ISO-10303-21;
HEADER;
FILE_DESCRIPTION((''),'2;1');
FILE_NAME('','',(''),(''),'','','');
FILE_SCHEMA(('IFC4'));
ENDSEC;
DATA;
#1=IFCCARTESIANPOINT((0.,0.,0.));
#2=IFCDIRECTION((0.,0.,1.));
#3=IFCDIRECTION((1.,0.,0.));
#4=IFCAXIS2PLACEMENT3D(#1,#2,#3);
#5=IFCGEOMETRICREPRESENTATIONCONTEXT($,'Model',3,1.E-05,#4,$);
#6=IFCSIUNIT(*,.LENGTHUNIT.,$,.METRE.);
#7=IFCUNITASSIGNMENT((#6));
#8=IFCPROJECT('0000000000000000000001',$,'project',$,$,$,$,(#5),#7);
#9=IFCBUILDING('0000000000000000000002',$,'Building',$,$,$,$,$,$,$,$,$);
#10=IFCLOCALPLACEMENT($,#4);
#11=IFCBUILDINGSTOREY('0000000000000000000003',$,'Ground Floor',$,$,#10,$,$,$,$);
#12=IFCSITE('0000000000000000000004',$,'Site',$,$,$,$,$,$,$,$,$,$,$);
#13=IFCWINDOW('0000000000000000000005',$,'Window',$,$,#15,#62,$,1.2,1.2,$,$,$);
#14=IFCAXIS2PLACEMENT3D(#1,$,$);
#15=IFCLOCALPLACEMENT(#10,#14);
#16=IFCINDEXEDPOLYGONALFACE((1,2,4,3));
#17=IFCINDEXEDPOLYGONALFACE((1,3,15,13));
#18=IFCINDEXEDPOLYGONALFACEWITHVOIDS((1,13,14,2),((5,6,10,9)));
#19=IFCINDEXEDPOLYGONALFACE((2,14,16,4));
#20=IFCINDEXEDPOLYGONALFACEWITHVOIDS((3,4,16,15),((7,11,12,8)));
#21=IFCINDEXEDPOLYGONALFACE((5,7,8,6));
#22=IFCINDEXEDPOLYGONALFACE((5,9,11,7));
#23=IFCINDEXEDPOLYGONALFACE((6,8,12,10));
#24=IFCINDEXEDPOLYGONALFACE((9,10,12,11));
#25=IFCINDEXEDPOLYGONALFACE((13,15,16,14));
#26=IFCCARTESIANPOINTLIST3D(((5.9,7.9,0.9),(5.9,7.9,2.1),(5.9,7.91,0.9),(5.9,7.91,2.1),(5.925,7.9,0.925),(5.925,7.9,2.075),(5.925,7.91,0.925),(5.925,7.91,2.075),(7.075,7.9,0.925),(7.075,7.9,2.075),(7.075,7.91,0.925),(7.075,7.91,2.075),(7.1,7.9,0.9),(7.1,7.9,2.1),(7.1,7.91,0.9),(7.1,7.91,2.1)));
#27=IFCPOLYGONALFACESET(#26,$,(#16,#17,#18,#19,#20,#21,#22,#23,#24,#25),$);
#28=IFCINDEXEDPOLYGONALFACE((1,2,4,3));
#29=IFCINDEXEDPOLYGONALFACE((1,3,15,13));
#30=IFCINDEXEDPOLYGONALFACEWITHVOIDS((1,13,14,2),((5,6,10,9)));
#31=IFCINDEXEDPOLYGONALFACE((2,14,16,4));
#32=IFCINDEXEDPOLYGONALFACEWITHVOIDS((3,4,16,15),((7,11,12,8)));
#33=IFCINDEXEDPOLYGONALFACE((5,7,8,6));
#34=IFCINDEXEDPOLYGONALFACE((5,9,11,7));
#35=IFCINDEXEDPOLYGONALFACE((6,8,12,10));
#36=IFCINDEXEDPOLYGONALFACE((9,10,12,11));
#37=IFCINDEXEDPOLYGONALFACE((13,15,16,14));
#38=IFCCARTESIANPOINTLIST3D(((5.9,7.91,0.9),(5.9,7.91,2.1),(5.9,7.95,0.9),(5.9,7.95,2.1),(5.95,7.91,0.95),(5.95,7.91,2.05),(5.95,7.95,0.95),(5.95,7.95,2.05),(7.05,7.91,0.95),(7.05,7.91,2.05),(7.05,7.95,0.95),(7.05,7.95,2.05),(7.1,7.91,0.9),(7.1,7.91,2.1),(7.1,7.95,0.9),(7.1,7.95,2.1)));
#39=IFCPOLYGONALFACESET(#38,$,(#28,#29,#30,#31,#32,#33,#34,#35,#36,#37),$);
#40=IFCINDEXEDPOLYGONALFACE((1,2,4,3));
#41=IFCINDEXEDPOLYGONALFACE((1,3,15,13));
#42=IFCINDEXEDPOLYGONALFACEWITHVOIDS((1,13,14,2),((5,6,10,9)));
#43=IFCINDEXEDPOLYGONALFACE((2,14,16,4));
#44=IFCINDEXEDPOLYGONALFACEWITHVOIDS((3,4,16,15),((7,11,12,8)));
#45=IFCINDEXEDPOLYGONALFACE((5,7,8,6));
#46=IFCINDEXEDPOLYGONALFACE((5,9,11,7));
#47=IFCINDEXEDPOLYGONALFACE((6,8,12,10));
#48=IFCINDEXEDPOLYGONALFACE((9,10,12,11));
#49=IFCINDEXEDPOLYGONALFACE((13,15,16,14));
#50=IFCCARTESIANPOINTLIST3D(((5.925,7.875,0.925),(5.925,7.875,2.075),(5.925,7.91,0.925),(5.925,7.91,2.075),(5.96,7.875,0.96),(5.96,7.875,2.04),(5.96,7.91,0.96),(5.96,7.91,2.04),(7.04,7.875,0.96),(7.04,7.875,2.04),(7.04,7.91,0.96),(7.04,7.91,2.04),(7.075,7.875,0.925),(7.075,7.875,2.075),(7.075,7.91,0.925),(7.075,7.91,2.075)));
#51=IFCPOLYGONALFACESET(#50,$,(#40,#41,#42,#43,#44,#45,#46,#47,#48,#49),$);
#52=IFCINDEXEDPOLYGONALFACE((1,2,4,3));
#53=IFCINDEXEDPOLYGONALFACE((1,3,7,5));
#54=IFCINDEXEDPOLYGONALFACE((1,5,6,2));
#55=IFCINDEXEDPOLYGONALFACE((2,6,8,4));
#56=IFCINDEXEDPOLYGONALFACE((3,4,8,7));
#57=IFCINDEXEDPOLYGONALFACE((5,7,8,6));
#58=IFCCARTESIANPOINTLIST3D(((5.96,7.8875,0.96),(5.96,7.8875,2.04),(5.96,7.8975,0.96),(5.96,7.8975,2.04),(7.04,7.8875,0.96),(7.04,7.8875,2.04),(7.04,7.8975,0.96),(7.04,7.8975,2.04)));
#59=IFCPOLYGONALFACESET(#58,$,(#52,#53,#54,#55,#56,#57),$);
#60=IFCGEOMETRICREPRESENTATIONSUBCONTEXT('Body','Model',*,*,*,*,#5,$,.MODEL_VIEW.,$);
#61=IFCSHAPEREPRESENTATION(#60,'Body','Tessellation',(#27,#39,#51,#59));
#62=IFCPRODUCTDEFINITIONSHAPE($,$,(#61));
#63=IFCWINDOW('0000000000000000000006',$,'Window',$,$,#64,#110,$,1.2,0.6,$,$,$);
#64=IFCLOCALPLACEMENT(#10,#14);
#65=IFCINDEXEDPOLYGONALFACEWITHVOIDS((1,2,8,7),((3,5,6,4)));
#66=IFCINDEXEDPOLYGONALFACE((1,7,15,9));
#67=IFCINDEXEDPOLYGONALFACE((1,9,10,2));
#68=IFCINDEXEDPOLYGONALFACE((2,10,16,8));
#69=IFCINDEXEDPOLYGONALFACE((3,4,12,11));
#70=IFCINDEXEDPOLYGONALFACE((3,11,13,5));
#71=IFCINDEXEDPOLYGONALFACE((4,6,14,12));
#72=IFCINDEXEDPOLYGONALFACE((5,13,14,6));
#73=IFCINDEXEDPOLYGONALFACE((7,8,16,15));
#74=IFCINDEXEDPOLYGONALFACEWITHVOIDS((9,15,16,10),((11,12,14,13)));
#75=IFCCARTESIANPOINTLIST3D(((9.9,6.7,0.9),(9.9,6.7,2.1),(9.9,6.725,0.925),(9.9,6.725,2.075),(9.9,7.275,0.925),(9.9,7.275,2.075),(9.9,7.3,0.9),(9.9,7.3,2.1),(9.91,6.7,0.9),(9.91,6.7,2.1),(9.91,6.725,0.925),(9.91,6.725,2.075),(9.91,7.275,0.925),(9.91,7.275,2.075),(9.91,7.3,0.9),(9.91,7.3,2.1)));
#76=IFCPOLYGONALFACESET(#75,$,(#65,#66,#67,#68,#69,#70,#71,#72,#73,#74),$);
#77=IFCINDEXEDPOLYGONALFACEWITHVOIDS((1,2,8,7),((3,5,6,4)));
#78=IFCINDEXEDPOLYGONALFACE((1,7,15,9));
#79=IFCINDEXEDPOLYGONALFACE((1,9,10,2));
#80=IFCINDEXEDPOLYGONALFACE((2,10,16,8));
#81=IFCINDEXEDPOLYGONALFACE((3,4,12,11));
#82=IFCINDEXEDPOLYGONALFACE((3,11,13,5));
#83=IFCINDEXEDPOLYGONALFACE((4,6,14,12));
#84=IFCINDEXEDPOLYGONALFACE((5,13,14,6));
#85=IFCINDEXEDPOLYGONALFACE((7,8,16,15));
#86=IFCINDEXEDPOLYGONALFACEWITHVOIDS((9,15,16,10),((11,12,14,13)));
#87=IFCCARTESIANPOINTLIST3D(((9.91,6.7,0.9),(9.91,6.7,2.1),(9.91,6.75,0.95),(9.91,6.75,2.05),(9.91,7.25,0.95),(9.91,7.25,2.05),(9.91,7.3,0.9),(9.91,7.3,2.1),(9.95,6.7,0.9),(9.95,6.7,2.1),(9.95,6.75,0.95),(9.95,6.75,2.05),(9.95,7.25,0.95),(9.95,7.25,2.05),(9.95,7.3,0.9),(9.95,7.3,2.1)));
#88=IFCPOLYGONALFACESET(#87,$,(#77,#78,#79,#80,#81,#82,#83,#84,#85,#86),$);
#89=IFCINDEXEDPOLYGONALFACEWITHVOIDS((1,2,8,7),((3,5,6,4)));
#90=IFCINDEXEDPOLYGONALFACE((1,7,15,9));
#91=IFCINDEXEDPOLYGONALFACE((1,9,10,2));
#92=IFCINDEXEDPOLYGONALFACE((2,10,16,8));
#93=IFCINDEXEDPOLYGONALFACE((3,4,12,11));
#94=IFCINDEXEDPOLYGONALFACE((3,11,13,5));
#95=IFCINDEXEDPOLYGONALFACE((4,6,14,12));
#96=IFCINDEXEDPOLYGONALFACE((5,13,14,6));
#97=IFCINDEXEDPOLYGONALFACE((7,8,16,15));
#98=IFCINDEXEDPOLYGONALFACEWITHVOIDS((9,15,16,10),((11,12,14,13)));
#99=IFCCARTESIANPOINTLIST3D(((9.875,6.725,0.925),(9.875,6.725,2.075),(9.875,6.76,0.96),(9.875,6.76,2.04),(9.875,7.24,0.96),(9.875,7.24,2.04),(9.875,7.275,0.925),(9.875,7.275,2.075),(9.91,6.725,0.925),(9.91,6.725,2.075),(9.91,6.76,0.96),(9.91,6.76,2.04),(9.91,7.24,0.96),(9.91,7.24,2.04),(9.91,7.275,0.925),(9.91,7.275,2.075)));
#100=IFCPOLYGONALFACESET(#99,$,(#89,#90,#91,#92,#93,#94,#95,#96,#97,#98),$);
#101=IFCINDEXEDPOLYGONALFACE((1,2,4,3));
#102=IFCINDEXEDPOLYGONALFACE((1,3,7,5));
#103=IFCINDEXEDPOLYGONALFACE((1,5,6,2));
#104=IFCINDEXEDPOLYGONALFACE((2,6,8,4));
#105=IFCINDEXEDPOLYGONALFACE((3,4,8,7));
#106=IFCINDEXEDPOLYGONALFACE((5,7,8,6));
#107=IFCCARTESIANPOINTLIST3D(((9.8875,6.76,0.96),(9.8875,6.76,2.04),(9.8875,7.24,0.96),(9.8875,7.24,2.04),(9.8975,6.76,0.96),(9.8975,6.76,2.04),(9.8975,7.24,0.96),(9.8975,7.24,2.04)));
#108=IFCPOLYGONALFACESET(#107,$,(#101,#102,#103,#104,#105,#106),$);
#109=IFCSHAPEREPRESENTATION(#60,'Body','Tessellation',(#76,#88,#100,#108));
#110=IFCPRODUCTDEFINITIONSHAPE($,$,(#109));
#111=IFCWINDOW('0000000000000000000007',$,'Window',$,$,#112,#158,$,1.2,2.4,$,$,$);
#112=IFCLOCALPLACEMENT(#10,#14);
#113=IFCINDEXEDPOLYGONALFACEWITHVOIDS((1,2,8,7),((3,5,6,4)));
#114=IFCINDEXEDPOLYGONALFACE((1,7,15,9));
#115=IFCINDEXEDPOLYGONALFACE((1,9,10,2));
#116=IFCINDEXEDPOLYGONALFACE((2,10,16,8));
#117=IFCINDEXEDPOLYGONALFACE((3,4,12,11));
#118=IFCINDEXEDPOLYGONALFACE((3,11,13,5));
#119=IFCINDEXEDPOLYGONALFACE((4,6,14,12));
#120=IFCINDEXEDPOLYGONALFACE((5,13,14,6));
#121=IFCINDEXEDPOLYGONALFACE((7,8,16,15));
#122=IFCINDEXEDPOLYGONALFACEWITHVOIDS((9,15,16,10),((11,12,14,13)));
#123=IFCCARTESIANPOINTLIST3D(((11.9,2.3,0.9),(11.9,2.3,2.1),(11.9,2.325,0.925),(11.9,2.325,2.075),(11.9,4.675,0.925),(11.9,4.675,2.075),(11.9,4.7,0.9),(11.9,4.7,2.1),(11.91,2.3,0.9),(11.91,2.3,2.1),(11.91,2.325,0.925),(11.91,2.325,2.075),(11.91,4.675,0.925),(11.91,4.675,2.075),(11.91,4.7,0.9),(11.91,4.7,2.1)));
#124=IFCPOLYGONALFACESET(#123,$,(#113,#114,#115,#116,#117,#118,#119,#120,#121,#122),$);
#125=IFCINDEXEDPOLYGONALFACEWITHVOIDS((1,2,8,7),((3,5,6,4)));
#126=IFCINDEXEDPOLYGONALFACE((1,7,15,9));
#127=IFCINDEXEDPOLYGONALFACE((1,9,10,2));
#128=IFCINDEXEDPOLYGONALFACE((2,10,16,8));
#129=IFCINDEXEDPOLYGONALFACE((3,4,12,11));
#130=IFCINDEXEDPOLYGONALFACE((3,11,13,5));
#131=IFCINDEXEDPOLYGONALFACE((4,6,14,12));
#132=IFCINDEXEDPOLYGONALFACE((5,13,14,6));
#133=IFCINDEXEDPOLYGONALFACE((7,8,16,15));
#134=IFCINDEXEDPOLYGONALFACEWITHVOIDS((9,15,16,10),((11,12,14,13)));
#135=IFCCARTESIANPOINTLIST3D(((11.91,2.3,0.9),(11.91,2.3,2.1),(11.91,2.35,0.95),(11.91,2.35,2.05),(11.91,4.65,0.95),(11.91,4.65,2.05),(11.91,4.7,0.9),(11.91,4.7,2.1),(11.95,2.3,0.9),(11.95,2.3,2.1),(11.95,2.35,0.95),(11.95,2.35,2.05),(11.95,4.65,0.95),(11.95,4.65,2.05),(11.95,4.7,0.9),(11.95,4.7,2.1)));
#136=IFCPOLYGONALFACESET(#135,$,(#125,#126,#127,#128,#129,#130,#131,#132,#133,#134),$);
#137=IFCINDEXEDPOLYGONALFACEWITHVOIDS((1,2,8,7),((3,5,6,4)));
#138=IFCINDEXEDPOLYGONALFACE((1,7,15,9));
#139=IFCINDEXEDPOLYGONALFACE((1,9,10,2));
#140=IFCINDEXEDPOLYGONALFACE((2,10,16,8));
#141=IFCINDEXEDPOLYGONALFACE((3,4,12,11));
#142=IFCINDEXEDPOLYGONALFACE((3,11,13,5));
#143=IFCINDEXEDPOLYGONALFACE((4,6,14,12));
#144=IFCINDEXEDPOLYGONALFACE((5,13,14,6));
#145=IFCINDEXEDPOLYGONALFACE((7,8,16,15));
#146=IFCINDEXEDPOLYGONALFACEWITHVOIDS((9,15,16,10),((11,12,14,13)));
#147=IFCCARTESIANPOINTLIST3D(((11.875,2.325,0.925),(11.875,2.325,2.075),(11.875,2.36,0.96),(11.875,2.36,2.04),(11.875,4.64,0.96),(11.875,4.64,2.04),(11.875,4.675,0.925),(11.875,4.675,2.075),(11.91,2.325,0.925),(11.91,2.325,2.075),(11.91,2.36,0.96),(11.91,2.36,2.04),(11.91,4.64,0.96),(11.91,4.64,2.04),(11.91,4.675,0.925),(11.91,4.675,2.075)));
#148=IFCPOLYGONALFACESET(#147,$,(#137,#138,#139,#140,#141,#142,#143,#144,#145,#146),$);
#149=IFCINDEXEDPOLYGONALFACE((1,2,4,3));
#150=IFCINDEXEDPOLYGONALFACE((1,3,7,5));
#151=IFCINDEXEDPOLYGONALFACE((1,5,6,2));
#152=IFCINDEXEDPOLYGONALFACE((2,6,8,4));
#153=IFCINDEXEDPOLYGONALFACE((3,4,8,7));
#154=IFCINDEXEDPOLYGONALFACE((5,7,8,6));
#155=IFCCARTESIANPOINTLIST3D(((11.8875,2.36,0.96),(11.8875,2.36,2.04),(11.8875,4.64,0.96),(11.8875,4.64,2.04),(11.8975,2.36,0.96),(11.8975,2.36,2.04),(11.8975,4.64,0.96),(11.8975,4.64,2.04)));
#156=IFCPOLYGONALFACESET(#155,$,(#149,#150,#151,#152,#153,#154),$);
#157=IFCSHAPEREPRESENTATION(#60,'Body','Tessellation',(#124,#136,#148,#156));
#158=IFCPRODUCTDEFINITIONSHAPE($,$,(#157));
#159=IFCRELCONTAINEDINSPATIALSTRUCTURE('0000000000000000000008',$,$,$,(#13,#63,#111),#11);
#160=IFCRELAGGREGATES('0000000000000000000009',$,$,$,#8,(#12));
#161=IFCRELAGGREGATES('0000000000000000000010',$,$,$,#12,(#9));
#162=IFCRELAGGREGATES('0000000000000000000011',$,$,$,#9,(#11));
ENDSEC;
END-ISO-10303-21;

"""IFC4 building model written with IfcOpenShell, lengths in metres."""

from ifc_helpers import new_model, si_unit, frame, origin_with_axes, place, context, subcontext, project, spatial, line, indexed_curve, outline, extrude, element, save


model = new_model("IFC4")

# Units and contexts
model_context = context("Model", 3, precision=1e-05, world=origin_with_axes())
body_context = subcontext(model_context, "Body", "Model", "MODEL_VIEW")
ifc_project = project(units=[si_unit("LENGTHUNIT", "METRE")], contexts=[model_context])

# Site, building, storey
site = spatial("IfcSite", under=ifc_project, Name="Site")
building = spatial("IfcBuilding", under=site, Name="Building")
storey_placement = place(None, origin_with_axes())
storey = spatial("IfcBuildingStorey", under=building, at=storey_placement, Name="Ground Floor")

# Windows
window_1_placement = place(storey_placement, frame((7.1, 8.0, 0.9), z_axis=(0.0, 0.0, 1.0), x_axis=(-1.0, 0.0, 0.0)))
element("IfcWindow", 1, at=window_1_placement, inside=storey, Name="Window", OverallHeight=1.2, OverallWidth=1.2, context=body_context, shape_type="SweptSolid", body=[
    extrude(outline(indexed_curve([(0.0, 0.0), (1.2, 0.0), (1.2, 1.2), (0.0, 1.2)], segments=[line(1, 2, 3, 4, 1)]), holes=[indexed_curve([(0.025, 0.025), (1.175, 0.025), (1.175, 1.175), (0.025, 1.175)], segments=[line(1, 2, 3, 4, 1)])]), frame((0.0, 0.09, 0.0), z_axis=(0.0, -1.0, 0.0), x_axis=(1.0, 0.0, 0.0)), (0.0, 0.0, -1.0), 0.01),
    extrude(outline(indexed_curve([(0.0, 0.0), (1.2, 0.0), (1.2, 1.2), (0.0, 1.2)], segments=[line(1, 2, 3, 4, 1)]), holes=[indexed_curve([(0.05, 0.05), (1.15, 0.05), (1.15, 1.15), (0.05, 1.15)], segments=[line(1, 2, 3, 4, 1)])]), frame((0.0, 0.05, 0.0), z_axis=(0.0, -1.0, 0.0), x_axis=(1.0, 0.0, 0.0)), (0.0, 0.0, -1.0), 0.04),
    extrude(outline(indexed_curve([(0.0, 0.0), (1.15, 0.0), (1.15, 1.15), (0.0, 1.15)], segments=[line(1, 2, 3, 4, 1)]), holes=[indexed_curve([(0.035, 0.035), (1.115, 0.035), (1.115, 1.115), (0.035, 1.115)], segments=[line(1, 2, 3, 4, 1)])]), frame((0.025, 0.09, 0.025), z_axis=(0.0, -1.0, 0.0), x_axis=(1.0, 0.0, 0.0)), (0.0, 0.0, -1.0), 0.035),
    extrude(outline(indexed_curve([(0.035, 0.035), (1.115, 0.035), (1.115, 1.115), (0.035, 1.115)], segments=[line(1, 2, 3, 4, 1)])), frame((0.025, 0.1025, 0.025), z_axis=(0.0, -1.0, 0.0), x_axis=(1.0, 0.0, 0.0)), (0.0, 0.0, -1.0), 0.01),
])
window_2_placement = place(storey_placement, frame((10.0, 6.7, 0.9), z_axis=(0.0, 0.0, 1.0), x_axis=(0.0, 1.0, 0.0)))
element("IfcWindow", 2, at=window_2_placement, inside=storey, Name="Window", OverallHeight=1.2, OverallWidth=0.6, context=body_context, shape_type="SweptSolid", body=[
    extrude(outline(indexed_curve([(0.0, 0.0), (0.6, 0.0), (0.6, 1.2), (0.0, 1.2)], segments=[line(1, 2, 3, 4, 1)]), holes=[indexed_curve([(0.025, 0.025), (0.575, 0.025), (0.575, 1.175), (0.025, 1.175)], segments=[line(1, 2, 3, 4, 1)])]), frame((0.0, 0.09, 0.0), z_axis=(0.0, -1.0, 0.0), x_axis=(1.0, 0.0, 0.0)), (0.0, 0.0, -1.0), 0.01),
    extrude(outline(indexed_curve([(0.0, 0.0), (0.6, 0.0), (0.6, 1.2), (0.0, 1.2)], segments=[line(1, 2, 3, 4, 1)]), holes=[indexed_curve([(0.05, 0.05), (0.55, 0.05), (0.55, 1.15), (0.05, 1.15)], segments=[line(1, 2, 3, 4, 1)])]), frame((0.0, 0.05, 0.0), z_axis=(0.0, -1.0, 0.0), x_axis=(1.0, 0.0, 0.0)), (0.0, 0.0, -1.0), 0.04),
    extrude(outline(indexed_curve([(0.0, 0.0), (0.55, 0.0), (0.55, 1.15), (0.0, 1.15)], segments=[line(1, 2, 3, 4, 1)]), holes=[indexed_curve([(0.035, 0.035), (0.515, 0.035), (0.515, 1.115), (0.035, 1.115)], segments=[line(1, 2, 3, 4, 1)])]), frame((0.025, 0.09, 0.025), z_axis=(0.0, -1.0, 0.0), x_axis=(1.0, 0.0, 0.0)), (0.0, 0.0, -1.0), 0.035),
    extrude(outline(indexed_curve([(0.035, 0.035), (0.515, 0.035), (0.515, 1.115), (0.035, 1.115)], segments=[line(1, 2, 3, 4, 1)])), frame((0.025, 0.1025, 0.025), z_axis=(0.0, -1.0, 0.0), x_axis=(1.0, 0.0, 0.0)), (0.0, 0.0, -1.0), 0.01),
])
window_3_placement = place(storey_placement, frame((12.0, 2.3, 0.9), z_axis=(0.0, 0.0, 1.0), x_axis=(0.0, 1.0, 0.0)))
element("IfcWindow", 3, at=window_3_placement, inside=storey, Name="Window", OverallHeight=1.2, OverallWidth=2.4, context=body_context, shape_type="SweptSolid", body=[
    extrude(outline(indexed_curve([(0.0, 0.0), (2.4, 0.0), (2.4, 1.2), (0.0, 1.2)], segments=[line(1, 2, 3, 4, 1)]), holes=[indexed_curve([(0.025, 0.025), (2.375, 0.025), (2.375, 1.175), (0.025, 1.175)], segments=[line(1, 2, 3, 4, 1)])]), frame((0.0, 0.09, 0.0), z_axis=(0.0, -1.0, 0.0), x_axis=(1.0, 0.0, 0.0)), (0.0, 0.0, -1.0), 0.01),
    extrude(outline(indexed_curve([(0.0, 0.0), (2.4, 0.0), (2.4, 1.2), (0.0, 1.2)], segments=[line(1, 2, 3, 4, 1)]), holes=[indexed_curve([(0.05, 0.05), (2.35, 0.05), (2.35, 1.15), (0.05, 1.15)], segments=[line(1, 2, 3, 4, 1)])]), frame((0.0, 0.05, 0.0), z_axis=(0.0, -1.0, 0.0), x_axis=(1.0, 0.0, 0.0)), (0.0, 0.0, -1.0), 0.04),
    extrude(outline(indexed_curve([(0.0, 0.0), (2.35, 0.0), (2.35, 1.15), (0.0, 1.15)], segments=[line(1, 2, 3, 4, 1)]), holes=[indexed_curve([(0.035, 0.035), (2.315, 0.035), (2.315, 1.115), (0.035, 1.115)], segments=[line(1, 2, 3, 4, 1)])]), frame((0.025, 0.09, 0.025), z_axis=(0.0, -1.0, 0.0), x_axis=(1.0, 0.0, 0.0)), (0.0, 0.0, -1.0), 0.035),
    extrude(outline(indexed_curve([(0.035, 0.035), (2.315, 0.035), (2.315, 1.115), (0.035, 1.115)], segments=[line(1, 2, 3, 4, 1)])), frame((0.025, 0.1025, 0.025), z_axis=(0.0, -1.0, 0.0), x_axis=(1.0, 0.0, 0.0)), (0.0, 0.0, -1.0), 0.01),
])

save(model, "model.ifc")
